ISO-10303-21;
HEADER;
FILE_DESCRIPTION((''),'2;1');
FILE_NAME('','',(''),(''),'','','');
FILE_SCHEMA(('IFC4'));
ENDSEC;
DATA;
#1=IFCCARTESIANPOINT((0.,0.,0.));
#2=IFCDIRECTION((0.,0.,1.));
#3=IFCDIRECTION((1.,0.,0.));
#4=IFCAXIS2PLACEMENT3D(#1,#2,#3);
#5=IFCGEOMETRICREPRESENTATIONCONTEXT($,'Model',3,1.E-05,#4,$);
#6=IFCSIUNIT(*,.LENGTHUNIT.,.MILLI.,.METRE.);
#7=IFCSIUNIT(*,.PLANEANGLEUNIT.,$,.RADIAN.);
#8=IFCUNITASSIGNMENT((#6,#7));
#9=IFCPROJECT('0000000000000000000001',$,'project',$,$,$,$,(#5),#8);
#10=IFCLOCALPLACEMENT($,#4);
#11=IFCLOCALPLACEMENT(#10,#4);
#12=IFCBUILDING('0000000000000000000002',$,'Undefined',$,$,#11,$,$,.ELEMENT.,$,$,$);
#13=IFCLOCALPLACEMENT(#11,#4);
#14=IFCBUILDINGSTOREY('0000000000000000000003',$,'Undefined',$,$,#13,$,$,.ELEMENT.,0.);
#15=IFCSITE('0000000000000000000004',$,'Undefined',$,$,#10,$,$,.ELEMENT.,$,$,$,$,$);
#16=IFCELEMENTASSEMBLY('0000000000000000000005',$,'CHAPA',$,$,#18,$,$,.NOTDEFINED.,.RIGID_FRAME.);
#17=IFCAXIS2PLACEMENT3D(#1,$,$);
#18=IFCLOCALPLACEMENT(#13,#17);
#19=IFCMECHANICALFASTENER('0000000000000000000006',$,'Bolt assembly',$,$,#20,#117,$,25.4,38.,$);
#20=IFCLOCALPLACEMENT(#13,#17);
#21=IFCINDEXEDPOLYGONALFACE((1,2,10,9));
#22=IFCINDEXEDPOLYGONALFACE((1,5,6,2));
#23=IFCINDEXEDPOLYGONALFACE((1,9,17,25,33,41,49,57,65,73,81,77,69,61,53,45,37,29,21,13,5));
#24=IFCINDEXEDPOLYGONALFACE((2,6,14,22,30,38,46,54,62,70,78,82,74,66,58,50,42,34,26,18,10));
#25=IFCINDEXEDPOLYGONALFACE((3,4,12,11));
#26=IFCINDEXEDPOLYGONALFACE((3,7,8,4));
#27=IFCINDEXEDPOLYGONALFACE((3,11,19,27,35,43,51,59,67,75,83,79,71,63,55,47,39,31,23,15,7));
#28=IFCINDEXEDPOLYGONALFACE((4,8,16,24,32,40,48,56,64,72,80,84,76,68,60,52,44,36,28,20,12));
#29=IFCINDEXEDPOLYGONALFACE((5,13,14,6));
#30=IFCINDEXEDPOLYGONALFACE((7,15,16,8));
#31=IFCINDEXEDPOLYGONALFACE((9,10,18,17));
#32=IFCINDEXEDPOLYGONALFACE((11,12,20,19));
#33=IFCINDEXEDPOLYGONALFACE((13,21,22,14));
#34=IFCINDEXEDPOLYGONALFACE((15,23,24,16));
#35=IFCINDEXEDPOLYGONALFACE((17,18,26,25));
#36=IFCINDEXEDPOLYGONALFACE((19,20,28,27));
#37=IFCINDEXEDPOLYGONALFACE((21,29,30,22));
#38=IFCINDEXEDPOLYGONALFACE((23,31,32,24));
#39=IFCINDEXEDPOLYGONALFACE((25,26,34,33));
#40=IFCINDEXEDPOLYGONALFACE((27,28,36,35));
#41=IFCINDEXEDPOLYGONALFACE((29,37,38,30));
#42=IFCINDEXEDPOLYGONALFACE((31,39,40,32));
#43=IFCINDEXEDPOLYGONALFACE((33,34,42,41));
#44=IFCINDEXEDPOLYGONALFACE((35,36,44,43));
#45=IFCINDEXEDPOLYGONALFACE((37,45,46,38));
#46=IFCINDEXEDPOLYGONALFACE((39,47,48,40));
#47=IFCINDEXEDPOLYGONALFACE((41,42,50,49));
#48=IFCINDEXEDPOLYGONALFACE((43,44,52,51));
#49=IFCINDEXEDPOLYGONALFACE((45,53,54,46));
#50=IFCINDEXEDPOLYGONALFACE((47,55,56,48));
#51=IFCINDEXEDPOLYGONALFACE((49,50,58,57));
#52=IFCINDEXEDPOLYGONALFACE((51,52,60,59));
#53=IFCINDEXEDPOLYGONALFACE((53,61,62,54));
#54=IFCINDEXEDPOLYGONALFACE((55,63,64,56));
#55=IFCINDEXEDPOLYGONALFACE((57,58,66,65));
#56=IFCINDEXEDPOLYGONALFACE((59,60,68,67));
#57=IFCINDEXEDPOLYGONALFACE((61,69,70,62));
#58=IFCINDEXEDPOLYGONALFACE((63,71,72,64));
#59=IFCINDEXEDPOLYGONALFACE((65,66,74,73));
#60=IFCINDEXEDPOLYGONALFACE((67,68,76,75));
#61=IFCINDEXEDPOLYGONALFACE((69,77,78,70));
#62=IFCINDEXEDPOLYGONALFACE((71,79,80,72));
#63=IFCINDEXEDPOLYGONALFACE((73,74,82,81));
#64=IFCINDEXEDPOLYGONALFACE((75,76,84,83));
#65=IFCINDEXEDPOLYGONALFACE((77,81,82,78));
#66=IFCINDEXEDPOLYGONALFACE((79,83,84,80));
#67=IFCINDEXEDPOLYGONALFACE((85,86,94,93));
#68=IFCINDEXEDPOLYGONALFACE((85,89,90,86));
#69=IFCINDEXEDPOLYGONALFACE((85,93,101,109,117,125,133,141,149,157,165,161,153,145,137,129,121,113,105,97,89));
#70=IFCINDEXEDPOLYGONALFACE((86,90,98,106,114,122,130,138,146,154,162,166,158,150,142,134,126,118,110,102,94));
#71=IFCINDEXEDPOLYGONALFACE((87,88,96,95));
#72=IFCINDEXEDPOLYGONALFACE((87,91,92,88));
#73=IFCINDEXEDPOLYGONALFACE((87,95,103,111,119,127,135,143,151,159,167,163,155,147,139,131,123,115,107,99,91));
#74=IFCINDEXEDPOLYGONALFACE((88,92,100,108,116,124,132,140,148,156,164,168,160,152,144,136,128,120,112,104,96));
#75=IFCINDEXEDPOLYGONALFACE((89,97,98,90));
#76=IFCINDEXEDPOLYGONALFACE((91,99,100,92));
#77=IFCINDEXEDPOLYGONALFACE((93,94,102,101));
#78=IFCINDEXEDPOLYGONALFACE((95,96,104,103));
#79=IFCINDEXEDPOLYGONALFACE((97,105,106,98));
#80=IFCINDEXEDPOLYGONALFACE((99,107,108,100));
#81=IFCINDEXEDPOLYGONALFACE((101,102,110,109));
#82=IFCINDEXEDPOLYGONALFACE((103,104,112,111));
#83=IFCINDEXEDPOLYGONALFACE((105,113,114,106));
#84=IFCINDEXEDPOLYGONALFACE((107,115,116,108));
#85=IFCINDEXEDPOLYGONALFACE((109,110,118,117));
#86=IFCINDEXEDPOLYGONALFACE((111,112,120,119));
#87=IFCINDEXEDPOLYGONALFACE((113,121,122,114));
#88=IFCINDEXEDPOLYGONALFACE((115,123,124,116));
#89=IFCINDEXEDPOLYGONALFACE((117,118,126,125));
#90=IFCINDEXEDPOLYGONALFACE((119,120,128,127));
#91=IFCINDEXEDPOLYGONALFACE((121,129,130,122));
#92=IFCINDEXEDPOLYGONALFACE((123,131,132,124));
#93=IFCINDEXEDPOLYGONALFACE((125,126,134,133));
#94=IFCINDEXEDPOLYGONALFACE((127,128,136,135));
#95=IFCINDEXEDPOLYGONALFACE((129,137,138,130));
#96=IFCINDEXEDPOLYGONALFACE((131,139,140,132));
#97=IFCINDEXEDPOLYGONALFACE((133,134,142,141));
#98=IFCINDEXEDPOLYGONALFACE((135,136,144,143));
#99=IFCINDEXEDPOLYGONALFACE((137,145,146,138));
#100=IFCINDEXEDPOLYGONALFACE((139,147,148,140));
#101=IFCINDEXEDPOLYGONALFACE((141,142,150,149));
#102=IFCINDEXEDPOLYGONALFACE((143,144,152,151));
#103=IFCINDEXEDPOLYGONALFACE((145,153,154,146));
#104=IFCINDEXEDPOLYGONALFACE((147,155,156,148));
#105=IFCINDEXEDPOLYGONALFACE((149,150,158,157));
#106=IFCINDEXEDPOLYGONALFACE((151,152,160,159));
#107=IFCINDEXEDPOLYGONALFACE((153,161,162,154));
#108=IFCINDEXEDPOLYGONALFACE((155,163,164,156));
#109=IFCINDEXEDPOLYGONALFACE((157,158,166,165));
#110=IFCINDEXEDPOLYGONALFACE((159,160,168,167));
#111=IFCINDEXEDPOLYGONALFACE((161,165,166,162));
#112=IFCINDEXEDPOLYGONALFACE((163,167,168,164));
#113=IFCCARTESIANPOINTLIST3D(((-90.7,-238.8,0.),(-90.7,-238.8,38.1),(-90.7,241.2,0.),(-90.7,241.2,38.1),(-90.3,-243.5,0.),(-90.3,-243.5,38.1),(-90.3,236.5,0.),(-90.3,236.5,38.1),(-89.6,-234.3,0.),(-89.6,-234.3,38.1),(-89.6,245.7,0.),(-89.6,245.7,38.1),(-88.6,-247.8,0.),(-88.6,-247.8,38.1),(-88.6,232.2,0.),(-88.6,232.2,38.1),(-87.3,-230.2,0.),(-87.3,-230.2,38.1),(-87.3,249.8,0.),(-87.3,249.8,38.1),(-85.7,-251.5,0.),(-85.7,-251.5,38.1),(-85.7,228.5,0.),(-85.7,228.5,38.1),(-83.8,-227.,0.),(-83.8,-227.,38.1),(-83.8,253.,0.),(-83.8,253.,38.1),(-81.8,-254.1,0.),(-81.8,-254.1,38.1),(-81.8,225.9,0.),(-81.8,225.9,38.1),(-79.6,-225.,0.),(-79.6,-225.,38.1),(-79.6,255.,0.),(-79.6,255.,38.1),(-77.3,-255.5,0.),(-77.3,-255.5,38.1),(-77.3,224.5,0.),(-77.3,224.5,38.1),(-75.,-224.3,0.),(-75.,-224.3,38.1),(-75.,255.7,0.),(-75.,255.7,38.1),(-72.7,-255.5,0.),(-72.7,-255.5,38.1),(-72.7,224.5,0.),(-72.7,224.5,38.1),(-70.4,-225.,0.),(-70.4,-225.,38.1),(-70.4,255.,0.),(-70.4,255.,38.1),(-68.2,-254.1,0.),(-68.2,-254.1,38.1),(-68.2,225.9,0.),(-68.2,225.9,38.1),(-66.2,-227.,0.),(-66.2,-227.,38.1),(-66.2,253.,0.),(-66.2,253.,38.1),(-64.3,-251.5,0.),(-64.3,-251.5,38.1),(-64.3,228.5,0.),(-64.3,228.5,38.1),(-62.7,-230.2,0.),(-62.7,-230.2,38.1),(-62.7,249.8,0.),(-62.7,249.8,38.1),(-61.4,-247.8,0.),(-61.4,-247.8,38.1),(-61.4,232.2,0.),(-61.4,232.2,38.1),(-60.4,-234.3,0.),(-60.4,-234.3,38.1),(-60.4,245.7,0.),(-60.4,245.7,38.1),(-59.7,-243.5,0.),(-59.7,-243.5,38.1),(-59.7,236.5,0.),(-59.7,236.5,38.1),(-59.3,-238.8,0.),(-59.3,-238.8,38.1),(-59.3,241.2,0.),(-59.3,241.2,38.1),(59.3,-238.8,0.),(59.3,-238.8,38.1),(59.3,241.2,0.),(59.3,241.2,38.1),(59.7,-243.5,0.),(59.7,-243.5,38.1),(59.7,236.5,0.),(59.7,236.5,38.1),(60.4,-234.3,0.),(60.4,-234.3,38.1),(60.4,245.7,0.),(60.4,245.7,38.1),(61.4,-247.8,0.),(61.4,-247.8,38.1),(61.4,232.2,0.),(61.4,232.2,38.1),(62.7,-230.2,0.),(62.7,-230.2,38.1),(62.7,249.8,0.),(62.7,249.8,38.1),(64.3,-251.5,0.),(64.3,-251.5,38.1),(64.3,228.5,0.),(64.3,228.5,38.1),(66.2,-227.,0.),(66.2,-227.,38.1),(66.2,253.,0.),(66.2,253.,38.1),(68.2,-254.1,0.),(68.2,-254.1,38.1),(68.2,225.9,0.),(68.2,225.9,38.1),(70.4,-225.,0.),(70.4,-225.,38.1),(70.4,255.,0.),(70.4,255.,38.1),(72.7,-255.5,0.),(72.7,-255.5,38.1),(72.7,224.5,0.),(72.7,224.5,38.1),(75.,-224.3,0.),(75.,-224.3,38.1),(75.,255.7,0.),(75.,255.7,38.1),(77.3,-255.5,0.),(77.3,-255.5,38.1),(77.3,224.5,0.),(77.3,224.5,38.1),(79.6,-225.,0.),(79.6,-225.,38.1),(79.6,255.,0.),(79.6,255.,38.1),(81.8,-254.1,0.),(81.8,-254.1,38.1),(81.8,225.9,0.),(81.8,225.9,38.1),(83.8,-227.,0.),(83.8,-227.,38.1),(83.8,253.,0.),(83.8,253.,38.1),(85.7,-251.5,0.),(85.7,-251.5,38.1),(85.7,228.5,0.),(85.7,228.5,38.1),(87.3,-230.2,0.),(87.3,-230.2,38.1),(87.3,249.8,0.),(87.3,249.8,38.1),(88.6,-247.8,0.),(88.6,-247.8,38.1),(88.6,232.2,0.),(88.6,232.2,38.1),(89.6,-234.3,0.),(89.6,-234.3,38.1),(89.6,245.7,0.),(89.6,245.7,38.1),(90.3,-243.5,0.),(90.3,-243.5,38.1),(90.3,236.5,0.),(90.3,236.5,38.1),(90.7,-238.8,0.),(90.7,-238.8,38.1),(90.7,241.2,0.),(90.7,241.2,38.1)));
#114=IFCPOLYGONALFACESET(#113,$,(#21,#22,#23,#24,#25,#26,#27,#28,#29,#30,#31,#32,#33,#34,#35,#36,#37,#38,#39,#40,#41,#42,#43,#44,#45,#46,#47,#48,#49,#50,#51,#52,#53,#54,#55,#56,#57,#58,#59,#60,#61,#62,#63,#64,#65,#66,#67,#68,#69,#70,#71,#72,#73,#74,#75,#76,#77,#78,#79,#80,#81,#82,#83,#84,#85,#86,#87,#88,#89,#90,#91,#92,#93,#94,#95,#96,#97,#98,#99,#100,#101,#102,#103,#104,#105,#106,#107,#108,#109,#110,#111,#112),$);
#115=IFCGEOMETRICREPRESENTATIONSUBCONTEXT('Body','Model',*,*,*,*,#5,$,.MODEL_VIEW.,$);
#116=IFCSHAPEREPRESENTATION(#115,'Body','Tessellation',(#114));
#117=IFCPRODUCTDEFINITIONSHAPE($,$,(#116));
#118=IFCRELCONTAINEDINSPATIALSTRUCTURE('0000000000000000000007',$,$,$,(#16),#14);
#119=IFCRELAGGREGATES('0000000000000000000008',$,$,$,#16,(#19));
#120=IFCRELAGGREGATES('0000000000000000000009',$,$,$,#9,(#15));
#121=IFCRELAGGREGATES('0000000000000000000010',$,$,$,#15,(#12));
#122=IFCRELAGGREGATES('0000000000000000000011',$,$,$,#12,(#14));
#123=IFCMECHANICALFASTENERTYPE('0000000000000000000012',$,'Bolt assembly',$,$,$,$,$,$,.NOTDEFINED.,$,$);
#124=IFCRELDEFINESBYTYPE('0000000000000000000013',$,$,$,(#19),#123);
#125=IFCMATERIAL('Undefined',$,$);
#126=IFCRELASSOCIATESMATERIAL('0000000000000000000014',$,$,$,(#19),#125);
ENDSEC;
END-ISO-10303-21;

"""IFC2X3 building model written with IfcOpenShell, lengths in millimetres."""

from ifc_helpers import new_model, si_unit, frame, origin_with_axes, origin_2d_with_axis, place, context, subcontext, project, spatial, circle, extrude, source, transform, mapped, material, type_object, element, aggregate, save


model = new_model("IFC2X3")

# Units and contexts
model_context = context("Model", 3, precision=1e-05, world=origin_with_axes())
body_context = subcontext(model_context, "Body", "Model", "MODEL_VIEW")
ifc_project = project(units=[si_unit("LENGTHUNIT", "METRE", prefix="MILLI"), si_unit("PLANEANGLEUNIT", "RADIAN")], contexts=[model_context])

# Site, building, storey
site_placement = place(None, origin_with_axes())
site = spatial("IfcSite", under=ifc_project, at=site_placement, Name="Undefined", CompositionType="ELEMENT")
building_placement = place(site_placement, origin_with_axes())
building = spatial("IfcBuilding", under=site, at=building_placement, Name="Undefined", CompositionType="ELEMENT")
storey_placement = place(building_placement, origin_with_axes())
storey = spatial("IfcBuildingStorey", under=building, at=storey_placement, Name="Undefined", CompositionType="ELEMENT", Elevation=0.0)

# Element assembly
assembly_1_placement = place(storey_placement, origin_with_axes())
assembly_1 = element("IfcElementAssembly", 1, at=assembly_1_placement, inside=storey, Name="CHAPA", AssemblyPlace="NOTDEFINED", PredefinedType="RIGID_FRAME")

# Shared definitions
ifc_material_1 = material(Name="Undefined")
mechanical_fastener_type = type_object("IfcMechanicalFastenerType", Name="Bolt assembly")

# Mechanical fastener
shared_shape_1 = source(origin_with_axes(), body_context, "Body", "SweptSolid", [
    extrude(circle(Radius=15.7, at=origin_2d_with_axis()), frame((0.0, -38.0, 0.0), z_axis=(0.0, 1.0, 0.0), x_axis=(1.0, 0.0, 0.0)), (0.0, 0.0, 1.0), 38.1),
])
mechanical_fastener_1_placement = place(assembly_1_placement, frame((0.0, -240.0, 38.0), z_axis=(1.0, 0.0, 0.0), x_axis=(0.0, 1.0, 0.0)))
mechanical_fastener_1 = element("IfcMechanicalFastener", 2, at=mechanical_fastener_1_placement, type_object=mechanical_fastener_type, material=ifc_material_1, Name="Bolt assembly", NominalDiameter=25.4, NominalLength=38.0, context=body_context, shape_type="MappedRepresentation", body=[
    mapped(shared_shape_1, transform((0.0, 0.0, -75.0))),
    mapped(shared_shape_1, transform((0.0, 0.0, 75.0))),
    mapped(shared_shape_1, transform((480.0, 0.0, -75.0))),
    mapped(shared_shape_1, transform((480.0, 0.0, 75.0))),
])
aggregate(assembly_1, [mechanical_fastener_1])

save(model, "model.ifc")
